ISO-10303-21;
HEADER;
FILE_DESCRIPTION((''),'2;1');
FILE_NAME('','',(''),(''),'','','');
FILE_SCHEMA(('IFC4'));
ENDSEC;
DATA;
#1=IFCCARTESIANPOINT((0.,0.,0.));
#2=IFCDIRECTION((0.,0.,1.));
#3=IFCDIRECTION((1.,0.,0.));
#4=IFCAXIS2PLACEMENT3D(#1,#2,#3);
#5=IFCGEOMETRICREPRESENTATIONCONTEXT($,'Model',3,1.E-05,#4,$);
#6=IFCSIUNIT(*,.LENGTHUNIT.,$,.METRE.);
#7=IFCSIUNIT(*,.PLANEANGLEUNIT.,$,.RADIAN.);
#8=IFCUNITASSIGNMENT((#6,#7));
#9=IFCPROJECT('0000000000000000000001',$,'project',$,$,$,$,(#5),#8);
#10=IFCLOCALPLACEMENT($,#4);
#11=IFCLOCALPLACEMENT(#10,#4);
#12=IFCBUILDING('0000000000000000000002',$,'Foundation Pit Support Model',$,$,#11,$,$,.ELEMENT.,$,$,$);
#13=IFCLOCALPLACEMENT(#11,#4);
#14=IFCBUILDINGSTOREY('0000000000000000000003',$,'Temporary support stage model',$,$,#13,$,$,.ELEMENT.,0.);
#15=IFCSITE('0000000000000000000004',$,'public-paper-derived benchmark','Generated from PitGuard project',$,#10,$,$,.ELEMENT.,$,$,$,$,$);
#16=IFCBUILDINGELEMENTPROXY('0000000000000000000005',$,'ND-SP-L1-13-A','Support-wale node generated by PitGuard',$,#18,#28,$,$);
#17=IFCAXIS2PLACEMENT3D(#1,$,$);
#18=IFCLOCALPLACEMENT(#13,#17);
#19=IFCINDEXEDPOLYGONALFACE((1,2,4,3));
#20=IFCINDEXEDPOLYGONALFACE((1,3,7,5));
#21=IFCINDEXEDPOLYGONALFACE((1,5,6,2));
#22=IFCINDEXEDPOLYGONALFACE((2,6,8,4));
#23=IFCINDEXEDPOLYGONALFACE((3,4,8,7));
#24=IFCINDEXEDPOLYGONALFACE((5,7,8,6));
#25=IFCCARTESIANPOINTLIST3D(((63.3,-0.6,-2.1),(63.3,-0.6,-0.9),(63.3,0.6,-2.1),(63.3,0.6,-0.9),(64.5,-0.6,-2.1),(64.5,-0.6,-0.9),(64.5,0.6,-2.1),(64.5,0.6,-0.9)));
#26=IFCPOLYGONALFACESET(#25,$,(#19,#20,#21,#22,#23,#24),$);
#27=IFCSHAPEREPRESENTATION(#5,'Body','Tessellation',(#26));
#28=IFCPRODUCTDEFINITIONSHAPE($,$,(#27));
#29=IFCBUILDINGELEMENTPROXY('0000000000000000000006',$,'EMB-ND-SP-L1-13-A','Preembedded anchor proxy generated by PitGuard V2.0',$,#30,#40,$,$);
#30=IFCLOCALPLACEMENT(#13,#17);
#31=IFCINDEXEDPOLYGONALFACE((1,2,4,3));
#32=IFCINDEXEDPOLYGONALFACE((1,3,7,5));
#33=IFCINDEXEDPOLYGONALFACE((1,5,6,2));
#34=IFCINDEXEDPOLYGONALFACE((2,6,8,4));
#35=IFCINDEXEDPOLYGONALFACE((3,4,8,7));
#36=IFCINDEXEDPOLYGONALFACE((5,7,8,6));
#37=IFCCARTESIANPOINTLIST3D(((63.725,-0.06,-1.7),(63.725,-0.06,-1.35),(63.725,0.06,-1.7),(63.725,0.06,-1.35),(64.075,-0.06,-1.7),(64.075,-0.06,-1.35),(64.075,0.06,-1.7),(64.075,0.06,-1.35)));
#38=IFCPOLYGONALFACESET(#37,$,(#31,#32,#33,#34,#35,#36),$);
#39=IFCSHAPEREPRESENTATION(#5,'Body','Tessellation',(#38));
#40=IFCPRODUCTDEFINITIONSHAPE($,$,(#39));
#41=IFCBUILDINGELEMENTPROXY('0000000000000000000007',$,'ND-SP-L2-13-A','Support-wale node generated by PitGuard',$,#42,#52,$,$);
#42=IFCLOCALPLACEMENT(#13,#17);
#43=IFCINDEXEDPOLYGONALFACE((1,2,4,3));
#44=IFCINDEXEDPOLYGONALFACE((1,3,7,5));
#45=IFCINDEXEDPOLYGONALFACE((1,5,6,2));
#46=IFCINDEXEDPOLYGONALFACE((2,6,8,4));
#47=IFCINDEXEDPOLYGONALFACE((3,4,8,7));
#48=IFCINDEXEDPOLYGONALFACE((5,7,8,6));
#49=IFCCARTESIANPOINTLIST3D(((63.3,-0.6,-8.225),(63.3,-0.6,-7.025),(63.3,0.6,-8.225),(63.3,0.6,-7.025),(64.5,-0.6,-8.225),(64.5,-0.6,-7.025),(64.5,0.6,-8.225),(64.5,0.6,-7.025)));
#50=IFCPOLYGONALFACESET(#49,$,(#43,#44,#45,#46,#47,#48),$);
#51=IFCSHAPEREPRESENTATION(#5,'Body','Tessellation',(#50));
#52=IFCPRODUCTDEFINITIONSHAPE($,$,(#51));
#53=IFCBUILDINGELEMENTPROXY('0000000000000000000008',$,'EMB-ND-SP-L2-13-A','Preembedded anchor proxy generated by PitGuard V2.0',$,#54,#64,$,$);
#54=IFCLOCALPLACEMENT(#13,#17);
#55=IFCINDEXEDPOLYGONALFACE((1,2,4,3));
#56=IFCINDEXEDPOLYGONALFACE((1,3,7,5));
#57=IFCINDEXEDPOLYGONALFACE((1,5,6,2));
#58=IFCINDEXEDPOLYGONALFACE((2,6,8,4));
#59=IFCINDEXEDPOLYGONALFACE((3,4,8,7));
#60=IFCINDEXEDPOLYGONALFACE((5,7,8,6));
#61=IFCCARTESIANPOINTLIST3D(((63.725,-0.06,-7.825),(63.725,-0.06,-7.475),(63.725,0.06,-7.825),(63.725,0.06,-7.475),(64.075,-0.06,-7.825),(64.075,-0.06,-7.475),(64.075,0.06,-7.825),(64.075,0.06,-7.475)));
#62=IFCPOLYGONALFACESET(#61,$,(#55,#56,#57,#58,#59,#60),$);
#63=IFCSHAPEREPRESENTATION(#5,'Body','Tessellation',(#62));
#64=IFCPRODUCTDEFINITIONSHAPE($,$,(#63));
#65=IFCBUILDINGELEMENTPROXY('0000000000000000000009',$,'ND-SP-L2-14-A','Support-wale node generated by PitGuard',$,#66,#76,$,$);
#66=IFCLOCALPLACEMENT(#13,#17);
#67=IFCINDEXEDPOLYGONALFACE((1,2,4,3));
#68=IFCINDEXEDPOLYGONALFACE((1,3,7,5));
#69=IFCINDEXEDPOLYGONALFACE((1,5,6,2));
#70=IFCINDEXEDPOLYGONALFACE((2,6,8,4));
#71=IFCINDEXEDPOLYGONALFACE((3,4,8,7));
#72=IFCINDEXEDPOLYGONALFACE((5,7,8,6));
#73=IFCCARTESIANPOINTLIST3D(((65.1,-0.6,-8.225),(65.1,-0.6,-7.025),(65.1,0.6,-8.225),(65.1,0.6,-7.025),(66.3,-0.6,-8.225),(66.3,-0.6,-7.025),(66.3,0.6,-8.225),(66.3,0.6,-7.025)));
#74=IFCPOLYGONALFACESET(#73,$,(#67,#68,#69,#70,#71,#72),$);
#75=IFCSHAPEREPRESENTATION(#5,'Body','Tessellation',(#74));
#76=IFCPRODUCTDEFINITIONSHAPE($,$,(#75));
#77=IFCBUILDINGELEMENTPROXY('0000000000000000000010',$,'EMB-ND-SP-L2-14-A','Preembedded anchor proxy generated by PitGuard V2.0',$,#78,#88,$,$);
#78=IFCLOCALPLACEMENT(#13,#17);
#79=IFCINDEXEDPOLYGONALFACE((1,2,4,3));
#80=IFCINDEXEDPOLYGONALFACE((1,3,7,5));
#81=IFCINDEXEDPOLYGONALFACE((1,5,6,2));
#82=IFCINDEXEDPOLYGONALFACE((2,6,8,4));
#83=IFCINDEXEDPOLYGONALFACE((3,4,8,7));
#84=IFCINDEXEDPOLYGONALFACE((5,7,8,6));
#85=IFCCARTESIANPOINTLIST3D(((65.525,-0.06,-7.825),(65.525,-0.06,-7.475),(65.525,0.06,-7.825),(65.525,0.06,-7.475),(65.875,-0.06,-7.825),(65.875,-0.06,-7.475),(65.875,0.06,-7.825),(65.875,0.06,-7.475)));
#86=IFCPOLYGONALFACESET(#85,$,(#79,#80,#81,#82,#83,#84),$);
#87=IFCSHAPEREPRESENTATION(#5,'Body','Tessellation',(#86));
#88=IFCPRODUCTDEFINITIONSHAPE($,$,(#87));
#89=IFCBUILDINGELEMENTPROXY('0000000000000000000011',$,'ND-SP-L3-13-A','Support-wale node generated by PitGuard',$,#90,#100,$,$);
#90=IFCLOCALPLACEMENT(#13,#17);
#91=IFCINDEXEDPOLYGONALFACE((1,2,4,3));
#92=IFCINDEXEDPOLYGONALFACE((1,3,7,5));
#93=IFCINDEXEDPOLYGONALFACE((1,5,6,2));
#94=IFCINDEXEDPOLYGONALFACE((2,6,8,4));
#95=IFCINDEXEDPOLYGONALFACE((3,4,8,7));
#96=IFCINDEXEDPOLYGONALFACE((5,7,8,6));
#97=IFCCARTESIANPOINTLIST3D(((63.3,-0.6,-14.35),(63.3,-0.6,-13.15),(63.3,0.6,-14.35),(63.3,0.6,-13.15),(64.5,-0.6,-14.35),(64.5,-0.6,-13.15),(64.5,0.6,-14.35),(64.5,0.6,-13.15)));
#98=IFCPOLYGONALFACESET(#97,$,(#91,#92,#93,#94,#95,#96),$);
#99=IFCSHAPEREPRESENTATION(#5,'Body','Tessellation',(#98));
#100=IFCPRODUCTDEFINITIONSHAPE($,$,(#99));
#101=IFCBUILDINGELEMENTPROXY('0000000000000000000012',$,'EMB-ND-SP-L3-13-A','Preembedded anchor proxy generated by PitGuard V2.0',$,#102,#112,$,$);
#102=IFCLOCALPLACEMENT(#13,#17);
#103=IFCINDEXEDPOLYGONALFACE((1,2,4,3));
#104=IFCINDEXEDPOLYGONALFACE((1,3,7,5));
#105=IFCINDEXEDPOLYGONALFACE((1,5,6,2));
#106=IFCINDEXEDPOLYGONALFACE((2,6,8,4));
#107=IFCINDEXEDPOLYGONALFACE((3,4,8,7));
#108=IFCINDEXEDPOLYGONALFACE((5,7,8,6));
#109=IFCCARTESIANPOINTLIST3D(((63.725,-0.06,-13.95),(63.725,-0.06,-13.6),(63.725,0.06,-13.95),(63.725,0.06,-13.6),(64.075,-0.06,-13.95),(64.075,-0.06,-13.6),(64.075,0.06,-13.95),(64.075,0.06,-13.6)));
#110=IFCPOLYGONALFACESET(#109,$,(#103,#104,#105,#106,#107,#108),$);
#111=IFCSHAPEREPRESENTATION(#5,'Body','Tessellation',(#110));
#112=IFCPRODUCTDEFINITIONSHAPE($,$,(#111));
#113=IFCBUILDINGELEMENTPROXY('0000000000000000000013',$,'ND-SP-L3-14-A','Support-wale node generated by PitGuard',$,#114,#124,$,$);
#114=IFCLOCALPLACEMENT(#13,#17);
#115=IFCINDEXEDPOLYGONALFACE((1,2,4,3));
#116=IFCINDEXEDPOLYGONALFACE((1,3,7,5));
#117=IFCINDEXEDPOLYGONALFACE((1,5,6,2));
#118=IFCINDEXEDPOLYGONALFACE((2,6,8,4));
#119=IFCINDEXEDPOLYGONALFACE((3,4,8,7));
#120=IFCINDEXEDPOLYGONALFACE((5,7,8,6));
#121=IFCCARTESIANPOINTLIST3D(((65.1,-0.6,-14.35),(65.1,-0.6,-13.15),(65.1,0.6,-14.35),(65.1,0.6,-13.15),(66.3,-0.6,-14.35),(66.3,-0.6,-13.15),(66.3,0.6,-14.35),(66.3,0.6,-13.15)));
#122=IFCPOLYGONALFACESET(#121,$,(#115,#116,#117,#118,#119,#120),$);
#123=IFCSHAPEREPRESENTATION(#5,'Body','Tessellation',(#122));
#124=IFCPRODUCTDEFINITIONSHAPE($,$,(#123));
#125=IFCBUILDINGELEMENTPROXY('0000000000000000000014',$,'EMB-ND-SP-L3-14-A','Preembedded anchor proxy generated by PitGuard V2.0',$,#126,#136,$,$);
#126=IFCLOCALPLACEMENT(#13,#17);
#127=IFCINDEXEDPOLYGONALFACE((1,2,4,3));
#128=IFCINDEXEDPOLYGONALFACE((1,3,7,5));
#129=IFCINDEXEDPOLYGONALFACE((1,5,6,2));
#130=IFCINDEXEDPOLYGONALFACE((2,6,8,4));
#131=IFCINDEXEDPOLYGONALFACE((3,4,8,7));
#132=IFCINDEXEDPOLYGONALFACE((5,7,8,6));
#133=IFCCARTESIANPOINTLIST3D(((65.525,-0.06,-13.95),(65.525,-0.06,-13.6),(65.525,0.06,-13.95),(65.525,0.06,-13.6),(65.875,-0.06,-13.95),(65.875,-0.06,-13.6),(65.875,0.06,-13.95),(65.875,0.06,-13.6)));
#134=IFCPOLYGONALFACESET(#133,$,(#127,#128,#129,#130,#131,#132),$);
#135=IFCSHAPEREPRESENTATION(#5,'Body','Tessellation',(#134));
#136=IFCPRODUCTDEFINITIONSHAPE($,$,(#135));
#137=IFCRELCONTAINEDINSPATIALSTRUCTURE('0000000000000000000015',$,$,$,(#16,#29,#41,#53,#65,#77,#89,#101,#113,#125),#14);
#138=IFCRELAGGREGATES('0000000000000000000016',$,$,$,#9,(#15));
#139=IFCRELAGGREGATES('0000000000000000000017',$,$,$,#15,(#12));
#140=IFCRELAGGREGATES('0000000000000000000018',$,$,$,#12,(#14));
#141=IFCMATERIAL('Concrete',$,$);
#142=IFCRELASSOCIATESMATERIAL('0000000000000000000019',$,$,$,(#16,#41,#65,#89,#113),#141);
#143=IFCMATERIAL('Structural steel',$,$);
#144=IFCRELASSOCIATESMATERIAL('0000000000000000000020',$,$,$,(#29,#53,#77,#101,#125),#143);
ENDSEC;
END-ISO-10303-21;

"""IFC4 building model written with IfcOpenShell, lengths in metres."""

from ifc_helpers import new_model, si_unit, frame, origin_with_axes, origin_2d, place, context, project, spatial, rectangle, extrude, material, element, save


model = new_model("IFC4")

# Units and contexts
model_context = context("Model", 3, precision=1e-05, world=origin_with_axes())
ifc_project = project(units=[si_unit("LENGTHUNIT", "METRE"), si_unit("PLANEANGLEUNIT", "RADIAN")], contexts=[model_context])

# Site, building, storey
site_placement = place(None, origin_with_axes())
site = spatial("IfcSite", under=ifc_project, at=site_placement, Name="public-paper-derived benchmark", Description="Generated from PitGuard project", CompositionType="ELEMENT")
building_placement = place(site_placement, origin_with_axes())
building = spatial("IfcBuilding", under=site, at=building_placement, Name="Foundation Pit Support Model", CompositionType="ELEMENT")
storey_placement = place(building_placement, origin_with_axes())
storey = spatial("IfcBuildingStorey", under=building, at=storey_placement, Name="Temporary support stage model", CompositionType="ELEMENT", Elevation=0.0)

# Shared definitions
ifc_material_1 = material(Name="Concrete")

# Shared definitions
ifc_material_2 = material(Name="Structural steel")

# Building element proxies
proxy_1_placement = place(storey_placement, frame((63.9, 0.0, -2.1), z_axis=(0.0, 0.0, 1.0), x_axis=(1.0, 0.0, 0.0)))
element("IfcBuildingElementProxy", 1, at=proxy_1_placement, inside=storey, material=ifc_material_1, Name="ND-SP-L1-13-A", Description="Support-wale node generated by PitGuard", context=model_context, shape_type="SweptSolid", body=[
    extrude(rectangle(XDim=1.2, YDim=1.2, at=origin_2d()), origin_with_axes(), (0.0, 0.0, 1.0), 1.2),
])
proxy_2_placement = place(storey_placement, frame((63.9, 0.0, -1.7), z_axis=(0.0, 0.0, 1.0), x_axis=(1.0, 0.0, 0.0)))
element("IfcBuildingElementProxy", 2, at=proxy_2_placement, inside=storey, material=ifc_material_2, Name="EMB-ND-SP-L1-13-A", Description="Preembedded anchor proxy generated by PitGuard V2.0", context=model_context, shape_type="SweptSolid", body=[
    extrude(rectangle(XDim=0.35, YDim=0.12, at=origin_2d()), origin_with_axes(), (0.0, 0.0, 1.0), 0.35),
])
proxy_3_placement = place(storey_placement, frame((63.9, 0.0, -8.225), z_axis=(0.0, 0.0, 1.0), x_axis=(1.0, 0.0, 0.0)))
element("IfcBuildingElementProxy", 3, at=proxy_3_placement, inside=storey, material=ifc_material_1, Name="ND-SP-L2-13-A", Description="Support-wale node generated by PitGuard", context=model_context, shape_type="SweptSolid", body=[
    extrude(rectangle(XDim=1.2, YDim=1.2, at=origin_2d()), origin_with_axes(), (0.0, 0.0, 1.0), 1.2),
])
proxy_4_placement = place(storey_placement, frame((63.9, 0.0, -7.825), z_axis=(0.0, 0.0, 1.0), x_axis=(1.0, 0.0, 0.0)))
element("IfcBuildingElementProxy", 4, at=proxy_4_placement, inside=storey, material=ifc_material_2, Name="EMB-ND-SP-L2-13-A", Description="Preembedded anchor proxy generated by PitGuard V2.0", context=model_context, shape_type="SweptSolid", body=[
    extrude(rectangle(XDim=0.35, YDim=0.12, at=origin_2d()), origin_with_axes(), (0.0, 0.0, 1.0), 0.35),
])
proxy_5_placement = place(storey_placement, frame((65.7, 0.0, -8.225), z_axis=(0.0, 0.0, 1.0), x_axis=(1.0, 0.0, 0.0)))
element("IfcBuildingElementProxy", 5, at=proxy_5_placement, inside=storey, material=ifc_material_1, Name="ND-SP-L2-14-A", Description="Support-wale node generated by PitGuard", context=model_context, shape_type="SweptSolid", body=[
    extrude(rectangle(XDim=1.2, YDim=1.2, at=origin_2d()), origin_with_axes(), (0.0, 0.0, 1.0), 1.2),
])
proxy_6_placement = place(storey_placement, frame((65.7, 0.0, -7.825), z_axis=(0.0, 0.0, 1.0), x_axis=(1.0, 0.0, 0.0)))
element("IfcBuildingElementProxy", 6, at=proxy_6_placement, inside=storey, material=ifc_material_2, Name="EMB-ND-SP-L2-14-A", Description="Preembedded anchor proxy generated by PitGuard V2.0", context=model_context, shape_type="SweptSolid", body=[
    extrude(rectangle(XDim=0.35, YDim=0.12, at=origin_2d()), origin_with_axes(), (0.0, 0.0, 1.0), 0.35),
])
proxy_7_placement = place(storey_placement, frame((63.9, 0.0, -14.35), z_axis=(0.0, 0.0, 1.0), x_axis=(1.0, 0.0, 0.0)))
element("IfcBuildingElementProxy", 7, at=proxy_7_placement, inside=storey, material=ifc_material_1, Name="ND-SP-L3-13-A", Description="Support-wale node generated by PitGuard", context=model_context, shape_type="SweptSolid", body=[
    extrude(rectangle(XDim=1.2, YDim=1.2, at=origin_2d()), origin_with_axes(), (0.0, 0.0, 1.0), 1.2),
])
proxy_8_placement = place(storey_placement, frame((63.9, 0.0, -13.95), z_axis=(0.0, 0.0, 1.0), x_axis=(1.0, 0.0, 0.0)))
element("IfcBuildingElementProxy", 8, at=proxy_8_placement, inside=storey, material=ifc_material_2, Name="EMB-ND-SP-L3-13-A", Description="Preembedded anchor proxy generated by PitGuard V2.0", context=model_context, shape_type="SweptSolid", body=[
    extrude(rectangle(XDim=0.35, YDim=0.12, at=origin_2d()), origin_with_axes(), (0.0, 0.0, 1.0), 0.35),
])
proxy_9_placement = place(storey_placement, frame((65.7, 0.0, -14.35), z_axis=(0.0, 0.0, 1.0), x_axis=(1.0, 0.0, 0.0)))
element("IfcBuildingElementProxy", 9, at=proxy_9_placement, inside=storey, material=ifc_material_1, Name="ND-SP-L3-14-A", Description="Support-wale node generated by PitGuard", context=model_context, shape_type="SweptSolid", body=[
    extrude(rectangle(XDim=1.2, YDim=1.2, at=origin_2d()), origin_with_axes(), (0.0, 0.0, 1.0), 1.2),
])
proxy_10_placement = place(storey_placement, frame((65.7, 0.0, -13.95), z_axis=(0.0, 0.0, 1.0), x_axis=(1.0, 0.0, 0.0)))
element("IfcBuildingElementProxy", 10, at=proxy_10_placement, inside=storey, material=ifc_material_2, Name="EMB-ND-SP-L3-14-A", Description="Preembedded anchor proxy generated by PitGuard V2.0", context=model_context, shape_type="SweptSolid", body=[
    extrude(rectangle(XDim=0.35, YDim=0.12, at=origin_2d()), origin_with_axes(), (0.0, 0.0, 1.0), 0.35),
])

save(model, "model.ifc")
